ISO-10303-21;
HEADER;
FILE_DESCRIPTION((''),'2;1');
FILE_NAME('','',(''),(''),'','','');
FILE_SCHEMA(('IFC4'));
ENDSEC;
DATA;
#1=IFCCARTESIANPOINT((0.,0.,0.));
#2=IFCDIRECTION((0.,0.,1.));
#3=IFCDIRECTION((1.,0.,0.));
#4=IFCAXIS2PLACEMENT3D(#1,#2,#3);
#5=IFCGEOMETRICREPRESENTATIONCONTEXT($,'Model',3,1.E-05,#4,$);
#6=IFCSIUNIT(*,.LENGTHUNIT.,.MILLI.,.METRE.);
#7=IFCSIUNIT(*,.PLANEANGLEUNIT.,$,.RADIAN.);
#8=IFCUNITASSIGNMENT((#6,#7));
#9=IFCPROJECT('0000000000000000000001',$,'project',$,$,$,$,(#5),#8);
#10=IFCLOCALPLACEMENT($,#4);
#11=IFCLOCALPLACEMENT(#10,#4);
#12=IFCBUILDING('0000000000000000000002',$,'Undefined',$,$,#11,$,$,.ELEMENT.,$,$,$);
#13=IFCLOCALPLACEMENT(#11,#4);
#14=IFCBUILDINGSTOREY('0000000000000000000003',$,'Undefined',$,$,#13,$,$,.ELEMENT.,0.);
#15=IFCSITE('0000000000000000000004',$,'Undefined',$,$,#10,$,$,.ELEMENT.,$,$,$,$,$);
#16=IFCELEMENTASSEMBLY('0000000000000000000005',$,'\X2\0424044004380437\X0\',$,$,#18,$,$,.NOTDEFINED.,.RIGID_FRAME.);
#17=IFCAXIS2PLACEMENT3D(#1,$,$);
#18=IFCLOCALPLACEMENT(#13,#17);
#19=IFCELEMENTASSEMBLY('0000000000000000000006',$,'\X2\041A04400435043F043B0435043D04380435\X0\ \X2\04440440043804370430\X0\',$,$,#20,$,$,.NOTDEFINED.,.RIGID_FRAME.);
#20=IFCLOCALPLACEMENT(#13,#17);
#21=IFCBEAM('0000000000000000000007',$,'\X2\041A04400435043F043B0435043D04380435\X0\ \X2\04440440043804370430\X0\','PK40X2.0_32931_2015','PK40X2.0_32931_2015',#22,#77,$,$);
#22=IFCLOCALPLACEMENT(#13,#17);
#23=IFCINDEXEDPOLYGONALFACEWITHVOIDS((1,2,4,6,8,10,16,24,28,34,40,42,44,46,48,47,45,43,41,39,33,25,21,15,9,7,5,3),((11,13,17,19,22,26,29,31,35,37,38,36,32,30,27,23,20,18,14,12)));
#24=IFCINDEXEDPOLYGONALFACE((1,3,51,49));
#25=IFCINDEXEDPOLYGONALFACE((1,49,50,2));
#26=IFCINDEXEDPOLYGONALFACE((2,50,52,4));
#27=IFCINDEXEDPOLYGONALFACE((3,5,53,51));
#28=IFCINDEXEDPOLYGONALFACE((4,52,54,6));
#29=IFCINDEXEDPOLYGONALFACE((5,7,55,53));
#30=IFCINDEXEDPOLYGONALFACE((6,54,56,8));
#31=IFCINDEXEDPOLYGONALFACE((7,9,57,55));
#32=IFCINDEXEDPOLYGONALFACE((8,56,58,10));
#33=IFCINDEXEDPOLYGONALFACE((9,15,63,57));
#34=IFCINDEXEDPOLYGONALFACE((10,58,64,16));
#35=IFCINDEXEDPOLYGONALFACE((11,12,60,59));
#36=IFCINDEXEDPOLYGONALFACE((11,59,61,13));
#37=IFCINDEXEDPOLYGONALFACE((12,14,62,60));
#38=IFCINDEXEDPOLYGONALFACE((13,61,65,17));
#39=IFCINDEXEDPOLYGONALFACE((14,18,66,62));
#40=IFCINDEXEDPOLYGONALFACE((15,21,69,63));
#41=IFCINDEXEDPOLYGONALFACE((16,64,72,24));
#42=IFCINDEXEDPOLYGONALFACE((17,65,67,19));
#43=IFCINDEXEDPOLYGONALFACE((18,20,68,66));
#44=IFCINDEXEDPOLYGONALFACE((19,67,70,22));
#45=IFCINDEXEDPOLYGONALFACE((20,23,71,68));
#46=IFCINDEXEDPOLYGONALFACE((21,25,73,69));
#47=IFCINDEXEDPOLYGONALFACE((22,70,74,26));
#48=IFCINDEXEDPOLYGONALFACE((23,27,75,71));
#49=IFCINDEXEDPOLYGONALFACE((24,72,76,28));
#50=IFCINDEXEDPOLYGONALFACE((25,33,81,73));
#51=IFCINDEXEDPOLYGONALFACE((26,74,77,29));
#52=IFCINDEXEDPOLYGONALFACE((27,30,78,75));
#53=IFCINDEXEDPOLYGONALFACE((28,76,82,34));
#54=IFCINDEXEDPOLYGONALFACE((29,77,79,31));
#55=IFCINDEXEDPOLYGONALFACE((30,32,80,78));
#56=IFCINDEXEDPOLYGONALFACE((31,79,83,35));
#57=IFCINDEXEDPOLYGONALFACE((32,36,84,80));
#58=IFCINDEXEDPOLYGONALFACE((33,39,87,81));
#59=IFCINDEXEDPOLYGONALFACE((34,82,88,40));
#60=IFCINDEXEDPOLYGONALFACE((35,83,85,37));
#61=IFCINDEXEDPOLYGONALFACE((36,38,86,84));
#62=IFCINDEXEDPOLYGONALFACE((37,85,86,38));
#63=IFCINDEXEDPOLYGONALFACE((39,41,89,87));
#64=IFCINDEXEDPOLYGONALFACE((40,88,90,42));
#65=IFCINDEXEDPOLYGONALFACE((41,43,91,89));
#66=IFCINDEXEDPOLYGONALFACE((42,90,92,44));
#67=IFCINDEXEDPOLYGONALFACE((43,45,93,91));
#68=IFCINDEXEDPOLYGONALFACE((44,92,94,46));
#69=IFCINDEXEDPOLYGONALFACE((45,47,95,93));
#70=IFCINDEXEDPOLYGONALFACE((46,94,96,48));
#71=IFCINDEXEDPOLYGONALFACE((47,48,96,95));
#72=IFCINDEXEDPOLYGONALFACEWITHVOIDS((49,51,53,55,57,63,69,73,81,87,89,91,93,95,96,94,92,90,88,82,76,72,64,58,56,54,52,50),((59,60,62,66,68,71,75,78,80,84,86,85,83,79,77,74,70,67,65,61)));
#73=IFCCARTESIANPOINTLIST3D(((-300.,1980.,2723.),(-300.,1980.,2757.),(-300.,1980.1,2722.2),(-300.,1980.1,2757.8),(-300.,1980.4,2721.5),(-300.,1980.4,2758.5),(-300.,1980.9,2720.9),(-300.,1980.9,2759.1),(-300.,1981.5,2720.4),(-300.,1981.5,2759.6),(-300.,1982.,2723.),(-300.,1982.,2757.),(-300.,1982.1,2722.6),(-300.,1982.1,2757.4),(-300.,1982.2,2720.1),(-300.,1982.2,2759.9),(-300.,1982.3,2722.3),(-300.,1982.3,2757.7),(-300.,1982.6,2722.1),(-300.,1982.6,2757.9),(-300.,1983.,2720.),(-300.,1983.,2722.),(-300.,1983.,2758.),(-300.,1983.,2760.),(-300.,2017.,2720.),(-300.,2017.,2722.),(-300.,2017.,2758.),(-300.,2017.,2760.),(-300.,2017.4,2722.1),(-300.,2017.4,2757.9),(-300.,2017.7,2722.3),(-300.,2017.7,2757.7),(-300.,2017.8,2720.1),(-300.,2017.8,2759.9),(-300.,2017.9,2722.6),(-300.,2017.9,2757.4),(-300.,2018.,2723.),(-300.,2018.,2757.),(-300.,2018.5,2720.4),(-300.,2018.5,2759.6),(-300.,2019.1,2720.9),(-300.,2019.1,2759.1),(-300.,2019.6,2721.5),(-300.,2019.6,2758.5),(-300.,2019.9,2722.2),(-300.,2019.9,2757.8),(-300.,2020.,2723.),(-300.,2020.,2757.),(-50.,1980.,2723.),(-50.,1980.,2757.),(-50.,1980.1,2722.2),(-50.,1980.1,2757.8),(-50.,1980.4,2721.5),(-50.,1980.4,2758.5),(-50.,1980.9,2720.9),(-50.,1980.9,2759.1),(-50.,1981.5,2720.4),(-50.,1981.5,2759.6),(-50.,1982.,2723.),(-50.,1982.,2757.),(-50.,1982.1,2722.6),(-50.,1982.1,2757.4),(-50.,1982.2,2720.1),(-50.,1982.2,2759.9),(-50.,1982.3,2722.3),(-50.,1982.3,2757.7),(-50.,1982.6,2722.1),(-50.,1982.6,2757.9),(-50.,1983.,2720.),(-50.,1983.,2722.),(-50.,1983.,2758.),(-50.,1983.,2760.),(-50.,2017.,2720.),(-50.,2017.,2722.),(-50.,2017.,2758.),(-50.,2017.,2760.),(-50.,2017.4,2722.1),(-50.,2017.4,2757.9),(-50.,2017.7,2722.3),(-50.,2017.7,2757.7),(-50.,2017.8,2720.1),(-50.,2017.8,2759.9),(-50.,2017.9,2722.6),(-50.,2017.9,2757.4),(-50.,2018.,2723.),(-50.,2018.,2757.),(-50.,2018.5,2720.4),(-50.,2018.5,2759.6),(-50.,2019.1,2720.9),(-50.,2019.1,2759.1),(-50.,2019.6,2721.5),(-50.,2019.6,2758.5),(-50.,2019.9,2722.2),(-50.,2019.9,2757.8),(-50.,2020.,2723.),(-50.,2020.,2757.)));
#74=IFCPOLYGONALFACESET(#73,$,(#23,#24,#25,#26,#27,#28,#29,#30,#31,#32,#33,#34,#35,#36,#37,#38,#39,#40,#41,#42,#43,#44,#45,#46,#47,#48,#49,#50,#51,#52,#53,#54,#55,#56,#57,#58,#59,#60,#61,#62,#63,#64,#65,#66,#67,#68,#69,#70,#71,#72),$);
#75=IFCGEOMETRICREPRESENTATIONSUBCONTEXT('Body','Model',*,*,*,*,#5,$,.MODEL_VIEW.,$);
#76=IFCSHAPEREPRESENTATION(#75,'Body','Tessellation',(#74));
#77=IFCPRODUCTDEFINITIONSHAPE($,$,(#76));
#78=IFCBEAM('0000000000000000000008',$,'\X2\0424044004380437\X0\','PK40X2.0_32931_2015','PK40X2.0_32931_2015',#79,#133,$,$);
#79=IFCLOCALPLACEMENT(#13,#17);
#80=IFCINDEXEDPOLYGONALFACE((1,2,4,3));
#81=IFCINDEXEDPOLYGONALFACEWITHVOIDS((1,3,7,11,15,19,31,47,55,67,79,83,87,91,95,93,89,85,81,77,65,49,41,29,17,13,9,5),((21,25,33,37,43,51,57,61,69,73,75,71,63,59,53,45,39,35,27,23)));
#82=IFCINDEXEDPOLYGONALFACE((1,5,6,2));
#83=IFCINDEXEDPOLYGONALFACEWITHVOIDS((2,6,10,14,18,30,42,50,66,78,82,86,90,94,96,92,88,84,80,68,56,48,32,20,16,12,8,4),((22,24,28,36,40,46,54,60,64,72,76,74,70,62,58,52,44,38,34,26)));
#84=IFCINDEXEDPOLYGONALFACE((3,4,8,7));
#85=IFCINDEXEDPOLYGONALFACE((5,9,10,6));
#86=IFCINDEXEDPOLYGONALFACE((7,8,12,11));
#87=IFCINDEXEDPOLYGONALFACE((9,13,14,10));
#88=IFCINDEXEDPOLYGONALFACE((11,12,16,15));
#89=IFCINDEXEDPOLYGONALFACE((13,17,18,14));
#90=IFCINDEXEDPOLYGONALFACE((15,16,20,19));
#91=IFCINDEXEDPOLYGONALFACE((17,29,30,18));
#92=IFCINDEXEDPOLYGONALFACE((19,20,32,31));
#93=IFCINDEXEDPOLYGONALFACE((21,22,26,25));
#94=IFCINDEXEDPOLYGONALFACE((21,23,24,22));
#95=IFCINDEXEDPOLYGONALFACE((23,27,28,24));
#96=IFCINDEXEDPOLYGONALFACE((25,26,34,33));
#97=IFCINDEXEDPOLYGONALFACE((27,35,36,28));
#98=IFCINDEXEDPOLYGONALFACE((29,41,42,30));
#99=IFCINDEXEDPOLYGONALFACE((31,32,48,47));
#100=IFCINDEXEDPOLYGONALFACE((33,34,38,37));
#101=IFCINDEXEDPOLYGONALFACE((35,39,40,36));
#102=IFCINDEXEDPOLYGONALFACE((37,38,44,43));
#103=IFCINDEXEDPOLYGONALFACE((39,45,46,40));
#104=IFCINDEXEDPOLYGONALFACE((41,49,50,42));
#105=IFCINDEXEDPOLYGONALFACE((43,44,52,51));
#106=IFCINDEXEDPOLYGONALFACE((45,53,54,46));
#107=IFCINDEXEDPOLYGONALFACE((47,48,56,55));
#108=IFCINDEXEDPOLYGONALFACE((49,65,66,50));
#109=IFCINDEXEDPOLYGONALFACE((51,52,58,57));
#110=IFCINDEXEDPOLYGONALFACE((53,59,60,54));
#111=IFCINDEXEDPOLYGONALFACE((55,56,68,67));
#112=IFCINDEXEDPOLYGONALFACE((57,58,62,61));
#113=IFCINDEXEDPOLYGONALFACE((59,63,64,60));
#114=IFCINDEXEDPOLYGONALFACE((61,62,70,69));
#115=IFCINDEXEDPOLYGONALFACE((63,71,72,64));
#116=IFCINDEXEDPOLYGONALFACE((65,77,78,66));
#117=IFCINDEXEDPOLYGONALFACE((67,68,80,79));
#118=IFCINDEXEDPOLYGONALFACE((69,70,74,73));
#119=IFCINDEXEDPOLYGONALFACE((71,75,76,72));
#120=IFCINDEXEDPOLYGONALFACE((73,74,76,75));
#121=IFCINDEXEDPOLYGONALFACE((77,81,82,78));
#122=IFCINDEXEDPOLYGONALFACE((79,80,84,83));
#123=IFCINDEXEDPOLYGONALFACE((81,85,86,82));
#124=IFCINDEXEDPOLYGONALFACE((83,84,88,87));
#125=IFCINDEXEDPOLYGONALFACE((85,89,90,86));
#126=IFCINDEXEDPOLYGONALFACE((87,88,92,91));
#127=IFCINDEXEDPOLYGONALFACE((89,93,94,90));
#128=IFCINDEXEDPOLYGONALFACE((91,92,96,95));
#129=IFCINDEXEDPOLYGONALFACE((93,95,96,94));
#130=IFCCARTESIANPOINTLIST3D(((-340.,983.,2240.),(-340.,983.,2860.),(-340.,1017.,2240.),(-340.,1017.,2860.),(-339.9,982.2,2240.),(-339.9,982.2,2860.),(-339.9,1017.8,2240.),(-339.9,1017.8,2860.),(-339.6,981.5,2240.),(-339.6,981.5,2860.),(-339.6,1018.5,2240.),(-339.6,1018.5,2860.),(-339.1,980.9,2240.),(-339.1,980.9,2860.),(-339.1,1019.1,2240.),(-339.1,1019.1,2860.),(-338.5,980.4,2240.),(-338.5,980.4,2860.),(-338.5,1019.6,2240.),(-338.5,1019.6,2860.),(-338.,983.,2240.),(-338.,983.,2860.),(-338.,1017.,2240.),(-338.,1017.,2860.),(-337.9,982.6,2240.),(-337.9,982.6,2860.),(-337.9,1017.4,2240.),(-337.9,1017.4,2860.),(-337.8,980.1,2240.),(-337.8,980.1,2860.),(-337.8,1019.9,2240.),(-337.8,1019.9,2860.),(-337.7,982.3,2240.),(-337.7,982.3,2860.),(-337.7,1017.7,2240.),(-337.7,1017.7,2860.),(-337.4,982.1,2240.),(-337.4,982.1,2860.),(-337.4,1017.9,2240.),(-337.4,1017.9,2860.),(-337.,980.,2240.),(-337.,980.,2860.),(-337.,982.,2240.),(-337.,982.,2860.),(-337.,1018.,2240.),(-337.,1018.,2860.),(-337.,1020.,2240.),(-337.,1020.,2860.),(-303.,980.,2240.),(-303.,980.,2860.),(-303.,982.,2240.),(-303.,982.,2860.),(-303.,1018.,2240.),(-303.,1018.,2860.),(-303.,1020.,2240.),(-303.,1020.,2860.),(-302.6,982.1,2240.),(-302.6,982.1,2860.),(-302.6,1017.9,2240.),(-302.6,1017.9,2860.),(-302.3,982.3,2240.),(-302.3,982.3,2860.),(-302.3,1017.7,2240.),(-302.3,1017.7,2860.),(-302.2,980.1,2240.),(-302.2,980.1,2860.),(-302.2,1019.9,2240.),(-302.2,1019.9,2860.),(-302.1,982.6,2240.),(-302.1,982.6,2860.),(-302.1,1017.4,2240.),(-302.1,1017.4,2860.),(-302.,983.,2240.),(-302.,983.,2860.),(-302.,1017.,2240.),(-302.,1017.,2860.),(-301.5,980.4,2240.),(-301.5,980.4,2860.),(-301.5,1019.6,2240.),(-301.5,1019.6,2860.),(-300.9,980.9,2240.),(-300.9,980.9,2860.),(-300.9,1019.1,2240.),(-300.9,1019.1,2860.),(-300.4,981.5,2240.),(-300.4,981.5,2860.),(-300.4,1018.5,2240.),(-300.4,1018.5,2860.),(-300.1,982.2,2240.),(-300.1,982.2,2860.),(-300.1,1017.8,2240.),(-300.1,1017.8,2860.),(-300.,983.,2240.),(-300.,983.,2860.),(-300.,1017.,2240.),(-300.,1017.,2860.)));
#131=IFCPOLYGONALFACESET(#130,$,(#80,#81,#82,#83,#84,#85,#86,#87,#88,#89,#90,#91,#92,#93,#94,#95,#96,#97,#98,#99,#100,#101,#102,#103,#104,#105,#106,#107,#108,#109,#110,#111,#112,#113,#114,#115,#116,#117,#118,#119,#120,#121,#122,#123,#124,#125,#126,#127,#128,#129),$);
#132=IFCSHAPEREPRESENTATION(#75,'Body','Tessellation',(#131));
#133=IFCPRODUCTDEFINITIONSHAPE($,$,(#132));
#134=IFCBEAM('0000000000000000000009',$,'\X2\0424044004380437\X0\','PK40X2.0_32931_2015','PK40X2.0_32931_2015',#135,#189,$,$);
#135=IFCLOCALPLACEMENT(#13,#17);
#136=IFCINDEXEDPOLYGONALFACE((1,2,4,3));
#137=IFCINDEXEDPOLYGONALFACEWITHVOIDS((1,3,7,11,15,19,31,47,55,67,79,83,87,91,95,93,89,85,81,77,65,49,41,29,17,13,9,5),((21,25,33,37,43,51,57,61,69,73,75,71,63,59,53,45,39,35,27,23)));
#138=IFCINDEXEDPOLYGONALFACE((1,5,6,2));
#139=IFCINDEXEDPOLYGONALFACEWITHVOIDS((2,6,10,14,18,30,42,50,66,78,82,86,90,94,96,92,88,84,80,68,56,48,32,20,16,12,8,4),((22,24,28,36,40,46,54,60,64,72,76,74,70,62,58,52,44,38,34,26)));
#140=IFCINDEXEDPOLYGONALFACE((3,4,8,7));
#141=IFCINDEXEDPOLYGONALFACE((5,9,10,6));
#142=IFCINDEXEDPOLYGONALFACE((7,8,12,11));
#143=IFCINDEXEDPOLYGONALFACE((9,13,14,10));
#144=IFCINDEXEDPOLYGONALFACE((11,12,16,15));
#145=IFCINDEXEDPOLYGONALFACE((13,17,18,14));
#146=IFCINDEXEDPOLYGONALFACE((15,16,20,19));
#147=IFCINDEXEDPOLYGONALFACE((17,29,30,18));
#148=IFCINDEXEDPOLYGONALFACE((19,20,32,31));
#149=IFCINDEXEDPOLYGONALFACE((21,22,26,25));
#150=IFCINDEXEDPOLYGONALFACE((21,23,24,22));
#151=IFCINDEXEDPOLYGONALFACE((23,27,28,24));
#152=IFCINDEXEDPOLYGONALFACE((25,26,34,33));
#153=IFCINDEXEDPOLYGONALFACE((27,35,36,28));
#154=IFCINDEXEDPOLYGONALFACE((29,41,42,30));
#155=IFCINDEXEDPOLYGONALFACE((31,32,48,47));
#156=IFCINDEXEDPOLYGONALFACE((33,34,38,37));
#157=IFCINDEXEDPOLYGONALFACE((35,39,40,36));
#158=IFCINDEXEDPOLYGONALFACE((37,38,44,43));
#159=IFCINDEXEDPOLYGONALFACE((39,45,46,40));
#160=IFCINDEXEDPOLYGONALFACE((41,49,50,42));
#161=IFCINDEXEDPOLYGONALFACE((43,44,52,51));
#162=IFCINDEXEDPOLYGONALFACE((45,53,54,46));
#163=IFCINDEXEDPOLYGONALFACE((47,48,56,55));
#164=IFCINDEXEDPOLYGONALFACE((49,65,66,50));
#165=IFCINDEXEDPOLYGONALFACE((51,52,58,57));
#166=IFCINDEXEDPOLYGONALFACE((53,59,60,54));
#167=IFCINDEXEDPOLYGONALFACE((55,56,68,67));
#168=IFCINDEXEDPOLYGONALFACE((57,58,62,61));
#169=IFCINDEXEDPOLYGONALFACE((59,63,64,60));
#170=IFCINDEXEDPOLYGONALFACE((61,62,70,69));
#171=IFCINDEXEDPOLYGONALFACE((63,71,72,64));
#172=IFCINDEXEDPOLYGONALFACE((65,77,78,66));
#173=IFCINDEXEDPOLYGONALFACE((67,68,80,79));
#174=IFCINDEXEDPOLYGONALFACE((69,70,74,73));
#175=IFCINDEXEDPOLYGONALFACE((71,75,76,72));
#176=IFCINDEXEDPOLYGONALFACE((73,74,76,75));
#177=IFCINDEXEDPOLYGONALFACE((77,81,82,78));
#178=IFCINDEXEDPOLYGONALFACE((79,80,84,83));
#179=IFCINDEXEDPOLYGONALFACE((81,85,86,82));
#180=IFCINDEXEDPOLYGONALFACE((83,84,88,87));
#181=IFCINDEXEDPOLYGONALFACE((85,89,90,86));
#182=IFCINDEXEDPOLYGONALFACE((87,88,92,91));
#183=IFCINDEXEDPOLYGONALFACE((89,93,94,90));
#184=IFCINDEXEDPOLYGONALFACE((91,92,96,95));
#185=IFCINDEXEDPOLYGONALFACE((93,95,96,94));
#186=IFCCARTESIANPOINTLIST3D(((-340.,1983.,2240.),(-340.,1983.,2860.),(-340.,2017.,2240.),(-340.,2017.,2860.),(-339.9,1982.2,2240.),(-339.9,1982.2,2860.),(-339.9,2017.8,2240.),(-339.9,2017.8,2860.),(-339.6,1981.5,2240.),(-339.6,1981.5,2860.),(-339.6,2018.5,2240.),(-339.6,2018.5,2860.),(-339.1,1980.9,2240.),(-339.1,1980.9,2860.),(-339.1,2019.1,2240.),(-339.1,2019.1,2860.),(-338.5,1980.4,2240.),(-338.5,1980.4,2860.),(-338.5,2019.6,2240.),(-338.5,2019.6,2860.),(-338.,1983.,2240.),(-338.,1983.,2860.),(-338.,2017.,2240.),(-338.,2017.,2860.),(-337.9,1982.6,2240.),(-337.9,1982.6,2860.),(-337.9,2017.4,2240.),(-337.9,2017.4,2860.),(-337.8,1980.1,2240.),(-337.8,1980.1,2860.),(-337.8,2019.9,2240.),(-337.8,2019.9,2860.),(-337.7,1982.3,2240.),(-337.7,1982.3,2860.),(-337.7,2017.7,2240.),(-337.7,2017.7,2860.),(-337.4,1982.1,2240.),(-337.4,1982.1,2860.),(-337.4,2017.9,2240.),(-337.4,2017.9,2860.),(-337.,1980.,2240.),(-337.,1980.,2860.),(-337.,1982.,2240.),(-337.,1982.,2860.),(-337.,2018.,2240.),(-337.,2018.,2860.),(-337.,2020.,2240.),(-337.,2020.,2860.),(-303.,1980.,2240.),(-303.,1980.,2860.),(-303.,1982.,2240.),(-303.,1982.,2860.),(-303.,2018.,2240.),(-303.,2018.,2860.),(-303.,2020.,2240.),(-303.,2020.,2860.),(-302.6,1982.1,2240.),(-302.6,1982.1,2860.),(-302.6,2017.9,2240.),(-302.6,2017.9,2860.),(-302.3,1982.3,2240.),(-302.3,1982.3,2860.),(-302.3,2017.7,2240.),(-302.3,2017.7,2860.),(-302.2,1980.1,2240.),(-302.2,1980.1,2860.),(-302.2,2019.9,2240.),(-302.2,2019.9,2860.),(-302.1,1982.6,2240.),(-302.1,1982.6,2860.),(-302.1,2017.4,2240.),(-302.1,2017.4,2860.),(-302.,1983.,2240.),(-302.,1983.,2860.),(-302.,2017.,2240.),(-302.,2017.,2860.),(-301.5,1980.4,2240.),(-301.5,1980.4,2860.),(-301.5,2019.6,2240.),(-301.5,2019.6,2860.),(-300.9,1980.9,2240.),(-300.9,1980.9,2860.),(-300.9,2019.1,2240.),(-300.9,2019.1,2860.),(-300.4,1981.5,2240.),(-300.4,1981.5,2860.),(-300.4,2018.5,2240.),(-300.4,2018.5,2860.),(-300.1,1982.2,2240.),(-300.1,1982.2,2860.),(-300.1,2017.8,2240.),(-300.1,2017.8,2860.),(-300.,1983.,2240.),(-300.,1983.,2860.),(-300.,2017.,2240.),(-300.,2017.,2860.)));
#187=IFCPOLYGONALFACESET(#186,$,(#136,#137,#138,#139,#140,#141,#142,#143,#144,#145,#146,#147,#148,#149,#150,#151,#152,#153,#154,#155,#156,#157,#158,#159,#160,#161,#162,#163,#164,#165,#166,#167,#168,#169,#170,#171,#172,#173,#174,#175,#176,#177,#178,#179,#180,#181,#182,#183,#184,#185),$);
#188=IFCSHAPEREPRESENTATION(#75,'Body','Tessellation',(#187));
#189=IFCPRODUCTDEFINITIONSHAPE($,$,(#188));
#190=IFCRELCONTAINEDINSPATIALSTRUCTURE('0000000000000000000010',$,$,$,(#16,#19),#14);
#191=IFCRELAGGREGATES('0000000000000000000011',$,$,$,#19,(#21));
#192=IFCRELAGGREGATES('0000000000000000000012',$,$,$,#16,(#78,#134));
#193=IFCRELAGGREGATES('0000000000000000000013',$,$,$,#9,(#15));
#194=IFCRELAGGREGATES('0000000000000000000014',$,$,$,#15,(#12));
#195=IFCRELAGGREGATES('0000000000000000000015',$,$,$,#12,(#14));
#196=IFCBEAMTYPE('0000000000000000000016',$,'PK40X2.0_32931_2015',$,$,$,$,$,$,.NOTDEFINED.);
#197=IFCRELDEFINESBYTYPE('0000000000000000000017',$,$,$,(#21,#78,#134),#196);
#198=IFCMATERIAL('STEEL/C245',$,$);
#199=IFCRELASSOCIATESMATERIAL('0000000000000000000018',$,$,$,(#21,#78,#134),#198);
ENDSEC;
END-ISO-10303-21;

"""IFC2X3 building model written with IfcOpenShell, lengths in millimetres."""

from ifc_helpers import new_model, si_unit, frame, origin_with_axes, origin_2d_with_axis, place, context, subcontext, project, spatial, hollow_rectangle, extrude, material, type_object, element, aggregate, save


model = new_model("IFC2X3")

# Units and contexts
model_context = context("Model", 3, precision=1e-05, world=origin_with_axes())
body_context = subcontext(model_context, "Body", "Model", "MODEL_VIEW")
ifc_project = project(units=[si_unit("LENGTHUNIT", "METRE", prefix="MILLI"), si_unit("PLANEANGLEUNIT", "RADIAN")], contexts=[model_context])

# Site, building, storey
site_placement = place(None, origin_with_axes())
site = spatial("IfcSite", under=ifc_project, at=site_placement, Name="Undefined", CompositionType="ELEMENT")
building_placement = place(site_placement, origin_with_axes())
building = spatial("IfcBuilding", under=site, at=building_placement, Name="Undefined", CompositionType="ELEMENT")
storey_placement = place(building_placement, origin_with_axes())
storey = spatial("IfcBuildingStorey", under=building, at=storey_placement, Name="Undefined", CompositionType="ELEMENT", Elevation=0.0)

# Shared definitions
ifc_material_1 = material(Name="STEEL/C245")

# Element assembly
assembly_1_placement = place(storey_placement, origin_with_axes())
assembly_1 = element("IfcElementAssembly", 1, at=assembly_1_placement, inside=storey, Name="Фриз", AssemblyPlace="NOTDEFINED", PredefinedType="RIGID_FRAME")

# Element assembly, beam
beam_type_1 = type_object("IfcBeamType", Name="PK40X2.0_32931_2015", PredefinedType="NOTDEFINED")
assembly_2_placement = place(storey_placement, origin_with_axes())
assembly_2 = element("IfcElementAssembly", 2, at=assembly_2_placement, inside=storey, Name="Крепление фриза", AssemblyPlace="NOTDEFINED", PredefinedType="RIGID_FRAME")
beam_1_placement = place(assembly_2_placement, frame((-300.0, 2000.0, 2740.0), z_axis=(0.0, 0.0, -1.0), x_axis=(1.0, 0.0, 0.0)))
beam_1 = element("IfcBeam", 3, at=beam_1_placement, type_object=beam_type_1, material=ifc_material_1, Name="Крепление фриза", Description="PK40X2.0_32931_2015", ObjectType="PK40X2.0_32931_2015", context=body_context, shape_type="SweptSolid", body=[
    extrude(hollow_rectangle(XDim=40.0, YDim=40.0, WallThickness=2.0, InnerFilletRadius=1.0, OuterFilletRadius=3.0, at=origin_2d_with_axis()), frame((250.0, 0.0, 0.0), z_axis=(-1.0, 0.0, 0.0), x_axis=(0.0, -1.0, 0.0)), (0.0, 0.0, 1.0), 250.0),
])
aggregate(assembly_2, [beam_1])

# Beams
beam_2_placement = place(assembly_1_placement, frame((-320.0, 1000.0, 2860.0), z_axis=(1.0, 0.0, 0.0), x_axis=(0.0, 0.0, -1.0)))
beam_2 = element("IfcBeam", 4, at=beam_2_placement, type_object=beam_type_1, material=ifc_material_1, Name="Фриз", Description="PK40X2.0_32931_2015", ObjectType="PK40X2.0_32931_2015", context=body_context, shape_type="SweptSolid", body=[
    extrude(hollow_rectangle(XDim=40.0, YDim=40.0, WallThickness=2.0, InnerFilletRadius=1.0, OuterFilletRadius=3.0, at=origin_2d_with_axis()), frame((620.0, 0.0, 0.0), z_axis=(-1.0, 0.0, 0.0), x_axis=(0.0, -1.0, 0.0)), (0.0, 0.0, 1.0), 620.0),
])
beam_3_placement = place(assembly_1_placement, frame((-320.0, 2000.0, 2860.0), z_axis=(1.0, 0.0, 0.0), x_axis=(0.0, 0.0, -1.0)))
beam_3 = element("IfcBeam", 5, at=beam_3_placement, type_object=beam_type_1, material=ifc_material_1, Name="Фриз", Description="PK40X2.0_32931_2015", ObjectType="PK40X2.0_32931_2015", context=body_context, shape_type="SweptSolid", body=[
    extrude(hollow_rectangle(XDim=40.0, YDim=40.0, WallThickness=2.0, InnerFilletRadius=1.0, OuterFilletRadius=3.0, at=origin_2d_with_axis()), frame((620.0, 0.0, 0.0), z_axis=(-1.0, 0.0, 0.0), x_axis=(0.0, -1.0, 0.0)), (0.0, 0.0, 1.0), 620.0),
])
aggregate(assembly_1, [beam_2, beam_3])

save(model, "model.ifc")
